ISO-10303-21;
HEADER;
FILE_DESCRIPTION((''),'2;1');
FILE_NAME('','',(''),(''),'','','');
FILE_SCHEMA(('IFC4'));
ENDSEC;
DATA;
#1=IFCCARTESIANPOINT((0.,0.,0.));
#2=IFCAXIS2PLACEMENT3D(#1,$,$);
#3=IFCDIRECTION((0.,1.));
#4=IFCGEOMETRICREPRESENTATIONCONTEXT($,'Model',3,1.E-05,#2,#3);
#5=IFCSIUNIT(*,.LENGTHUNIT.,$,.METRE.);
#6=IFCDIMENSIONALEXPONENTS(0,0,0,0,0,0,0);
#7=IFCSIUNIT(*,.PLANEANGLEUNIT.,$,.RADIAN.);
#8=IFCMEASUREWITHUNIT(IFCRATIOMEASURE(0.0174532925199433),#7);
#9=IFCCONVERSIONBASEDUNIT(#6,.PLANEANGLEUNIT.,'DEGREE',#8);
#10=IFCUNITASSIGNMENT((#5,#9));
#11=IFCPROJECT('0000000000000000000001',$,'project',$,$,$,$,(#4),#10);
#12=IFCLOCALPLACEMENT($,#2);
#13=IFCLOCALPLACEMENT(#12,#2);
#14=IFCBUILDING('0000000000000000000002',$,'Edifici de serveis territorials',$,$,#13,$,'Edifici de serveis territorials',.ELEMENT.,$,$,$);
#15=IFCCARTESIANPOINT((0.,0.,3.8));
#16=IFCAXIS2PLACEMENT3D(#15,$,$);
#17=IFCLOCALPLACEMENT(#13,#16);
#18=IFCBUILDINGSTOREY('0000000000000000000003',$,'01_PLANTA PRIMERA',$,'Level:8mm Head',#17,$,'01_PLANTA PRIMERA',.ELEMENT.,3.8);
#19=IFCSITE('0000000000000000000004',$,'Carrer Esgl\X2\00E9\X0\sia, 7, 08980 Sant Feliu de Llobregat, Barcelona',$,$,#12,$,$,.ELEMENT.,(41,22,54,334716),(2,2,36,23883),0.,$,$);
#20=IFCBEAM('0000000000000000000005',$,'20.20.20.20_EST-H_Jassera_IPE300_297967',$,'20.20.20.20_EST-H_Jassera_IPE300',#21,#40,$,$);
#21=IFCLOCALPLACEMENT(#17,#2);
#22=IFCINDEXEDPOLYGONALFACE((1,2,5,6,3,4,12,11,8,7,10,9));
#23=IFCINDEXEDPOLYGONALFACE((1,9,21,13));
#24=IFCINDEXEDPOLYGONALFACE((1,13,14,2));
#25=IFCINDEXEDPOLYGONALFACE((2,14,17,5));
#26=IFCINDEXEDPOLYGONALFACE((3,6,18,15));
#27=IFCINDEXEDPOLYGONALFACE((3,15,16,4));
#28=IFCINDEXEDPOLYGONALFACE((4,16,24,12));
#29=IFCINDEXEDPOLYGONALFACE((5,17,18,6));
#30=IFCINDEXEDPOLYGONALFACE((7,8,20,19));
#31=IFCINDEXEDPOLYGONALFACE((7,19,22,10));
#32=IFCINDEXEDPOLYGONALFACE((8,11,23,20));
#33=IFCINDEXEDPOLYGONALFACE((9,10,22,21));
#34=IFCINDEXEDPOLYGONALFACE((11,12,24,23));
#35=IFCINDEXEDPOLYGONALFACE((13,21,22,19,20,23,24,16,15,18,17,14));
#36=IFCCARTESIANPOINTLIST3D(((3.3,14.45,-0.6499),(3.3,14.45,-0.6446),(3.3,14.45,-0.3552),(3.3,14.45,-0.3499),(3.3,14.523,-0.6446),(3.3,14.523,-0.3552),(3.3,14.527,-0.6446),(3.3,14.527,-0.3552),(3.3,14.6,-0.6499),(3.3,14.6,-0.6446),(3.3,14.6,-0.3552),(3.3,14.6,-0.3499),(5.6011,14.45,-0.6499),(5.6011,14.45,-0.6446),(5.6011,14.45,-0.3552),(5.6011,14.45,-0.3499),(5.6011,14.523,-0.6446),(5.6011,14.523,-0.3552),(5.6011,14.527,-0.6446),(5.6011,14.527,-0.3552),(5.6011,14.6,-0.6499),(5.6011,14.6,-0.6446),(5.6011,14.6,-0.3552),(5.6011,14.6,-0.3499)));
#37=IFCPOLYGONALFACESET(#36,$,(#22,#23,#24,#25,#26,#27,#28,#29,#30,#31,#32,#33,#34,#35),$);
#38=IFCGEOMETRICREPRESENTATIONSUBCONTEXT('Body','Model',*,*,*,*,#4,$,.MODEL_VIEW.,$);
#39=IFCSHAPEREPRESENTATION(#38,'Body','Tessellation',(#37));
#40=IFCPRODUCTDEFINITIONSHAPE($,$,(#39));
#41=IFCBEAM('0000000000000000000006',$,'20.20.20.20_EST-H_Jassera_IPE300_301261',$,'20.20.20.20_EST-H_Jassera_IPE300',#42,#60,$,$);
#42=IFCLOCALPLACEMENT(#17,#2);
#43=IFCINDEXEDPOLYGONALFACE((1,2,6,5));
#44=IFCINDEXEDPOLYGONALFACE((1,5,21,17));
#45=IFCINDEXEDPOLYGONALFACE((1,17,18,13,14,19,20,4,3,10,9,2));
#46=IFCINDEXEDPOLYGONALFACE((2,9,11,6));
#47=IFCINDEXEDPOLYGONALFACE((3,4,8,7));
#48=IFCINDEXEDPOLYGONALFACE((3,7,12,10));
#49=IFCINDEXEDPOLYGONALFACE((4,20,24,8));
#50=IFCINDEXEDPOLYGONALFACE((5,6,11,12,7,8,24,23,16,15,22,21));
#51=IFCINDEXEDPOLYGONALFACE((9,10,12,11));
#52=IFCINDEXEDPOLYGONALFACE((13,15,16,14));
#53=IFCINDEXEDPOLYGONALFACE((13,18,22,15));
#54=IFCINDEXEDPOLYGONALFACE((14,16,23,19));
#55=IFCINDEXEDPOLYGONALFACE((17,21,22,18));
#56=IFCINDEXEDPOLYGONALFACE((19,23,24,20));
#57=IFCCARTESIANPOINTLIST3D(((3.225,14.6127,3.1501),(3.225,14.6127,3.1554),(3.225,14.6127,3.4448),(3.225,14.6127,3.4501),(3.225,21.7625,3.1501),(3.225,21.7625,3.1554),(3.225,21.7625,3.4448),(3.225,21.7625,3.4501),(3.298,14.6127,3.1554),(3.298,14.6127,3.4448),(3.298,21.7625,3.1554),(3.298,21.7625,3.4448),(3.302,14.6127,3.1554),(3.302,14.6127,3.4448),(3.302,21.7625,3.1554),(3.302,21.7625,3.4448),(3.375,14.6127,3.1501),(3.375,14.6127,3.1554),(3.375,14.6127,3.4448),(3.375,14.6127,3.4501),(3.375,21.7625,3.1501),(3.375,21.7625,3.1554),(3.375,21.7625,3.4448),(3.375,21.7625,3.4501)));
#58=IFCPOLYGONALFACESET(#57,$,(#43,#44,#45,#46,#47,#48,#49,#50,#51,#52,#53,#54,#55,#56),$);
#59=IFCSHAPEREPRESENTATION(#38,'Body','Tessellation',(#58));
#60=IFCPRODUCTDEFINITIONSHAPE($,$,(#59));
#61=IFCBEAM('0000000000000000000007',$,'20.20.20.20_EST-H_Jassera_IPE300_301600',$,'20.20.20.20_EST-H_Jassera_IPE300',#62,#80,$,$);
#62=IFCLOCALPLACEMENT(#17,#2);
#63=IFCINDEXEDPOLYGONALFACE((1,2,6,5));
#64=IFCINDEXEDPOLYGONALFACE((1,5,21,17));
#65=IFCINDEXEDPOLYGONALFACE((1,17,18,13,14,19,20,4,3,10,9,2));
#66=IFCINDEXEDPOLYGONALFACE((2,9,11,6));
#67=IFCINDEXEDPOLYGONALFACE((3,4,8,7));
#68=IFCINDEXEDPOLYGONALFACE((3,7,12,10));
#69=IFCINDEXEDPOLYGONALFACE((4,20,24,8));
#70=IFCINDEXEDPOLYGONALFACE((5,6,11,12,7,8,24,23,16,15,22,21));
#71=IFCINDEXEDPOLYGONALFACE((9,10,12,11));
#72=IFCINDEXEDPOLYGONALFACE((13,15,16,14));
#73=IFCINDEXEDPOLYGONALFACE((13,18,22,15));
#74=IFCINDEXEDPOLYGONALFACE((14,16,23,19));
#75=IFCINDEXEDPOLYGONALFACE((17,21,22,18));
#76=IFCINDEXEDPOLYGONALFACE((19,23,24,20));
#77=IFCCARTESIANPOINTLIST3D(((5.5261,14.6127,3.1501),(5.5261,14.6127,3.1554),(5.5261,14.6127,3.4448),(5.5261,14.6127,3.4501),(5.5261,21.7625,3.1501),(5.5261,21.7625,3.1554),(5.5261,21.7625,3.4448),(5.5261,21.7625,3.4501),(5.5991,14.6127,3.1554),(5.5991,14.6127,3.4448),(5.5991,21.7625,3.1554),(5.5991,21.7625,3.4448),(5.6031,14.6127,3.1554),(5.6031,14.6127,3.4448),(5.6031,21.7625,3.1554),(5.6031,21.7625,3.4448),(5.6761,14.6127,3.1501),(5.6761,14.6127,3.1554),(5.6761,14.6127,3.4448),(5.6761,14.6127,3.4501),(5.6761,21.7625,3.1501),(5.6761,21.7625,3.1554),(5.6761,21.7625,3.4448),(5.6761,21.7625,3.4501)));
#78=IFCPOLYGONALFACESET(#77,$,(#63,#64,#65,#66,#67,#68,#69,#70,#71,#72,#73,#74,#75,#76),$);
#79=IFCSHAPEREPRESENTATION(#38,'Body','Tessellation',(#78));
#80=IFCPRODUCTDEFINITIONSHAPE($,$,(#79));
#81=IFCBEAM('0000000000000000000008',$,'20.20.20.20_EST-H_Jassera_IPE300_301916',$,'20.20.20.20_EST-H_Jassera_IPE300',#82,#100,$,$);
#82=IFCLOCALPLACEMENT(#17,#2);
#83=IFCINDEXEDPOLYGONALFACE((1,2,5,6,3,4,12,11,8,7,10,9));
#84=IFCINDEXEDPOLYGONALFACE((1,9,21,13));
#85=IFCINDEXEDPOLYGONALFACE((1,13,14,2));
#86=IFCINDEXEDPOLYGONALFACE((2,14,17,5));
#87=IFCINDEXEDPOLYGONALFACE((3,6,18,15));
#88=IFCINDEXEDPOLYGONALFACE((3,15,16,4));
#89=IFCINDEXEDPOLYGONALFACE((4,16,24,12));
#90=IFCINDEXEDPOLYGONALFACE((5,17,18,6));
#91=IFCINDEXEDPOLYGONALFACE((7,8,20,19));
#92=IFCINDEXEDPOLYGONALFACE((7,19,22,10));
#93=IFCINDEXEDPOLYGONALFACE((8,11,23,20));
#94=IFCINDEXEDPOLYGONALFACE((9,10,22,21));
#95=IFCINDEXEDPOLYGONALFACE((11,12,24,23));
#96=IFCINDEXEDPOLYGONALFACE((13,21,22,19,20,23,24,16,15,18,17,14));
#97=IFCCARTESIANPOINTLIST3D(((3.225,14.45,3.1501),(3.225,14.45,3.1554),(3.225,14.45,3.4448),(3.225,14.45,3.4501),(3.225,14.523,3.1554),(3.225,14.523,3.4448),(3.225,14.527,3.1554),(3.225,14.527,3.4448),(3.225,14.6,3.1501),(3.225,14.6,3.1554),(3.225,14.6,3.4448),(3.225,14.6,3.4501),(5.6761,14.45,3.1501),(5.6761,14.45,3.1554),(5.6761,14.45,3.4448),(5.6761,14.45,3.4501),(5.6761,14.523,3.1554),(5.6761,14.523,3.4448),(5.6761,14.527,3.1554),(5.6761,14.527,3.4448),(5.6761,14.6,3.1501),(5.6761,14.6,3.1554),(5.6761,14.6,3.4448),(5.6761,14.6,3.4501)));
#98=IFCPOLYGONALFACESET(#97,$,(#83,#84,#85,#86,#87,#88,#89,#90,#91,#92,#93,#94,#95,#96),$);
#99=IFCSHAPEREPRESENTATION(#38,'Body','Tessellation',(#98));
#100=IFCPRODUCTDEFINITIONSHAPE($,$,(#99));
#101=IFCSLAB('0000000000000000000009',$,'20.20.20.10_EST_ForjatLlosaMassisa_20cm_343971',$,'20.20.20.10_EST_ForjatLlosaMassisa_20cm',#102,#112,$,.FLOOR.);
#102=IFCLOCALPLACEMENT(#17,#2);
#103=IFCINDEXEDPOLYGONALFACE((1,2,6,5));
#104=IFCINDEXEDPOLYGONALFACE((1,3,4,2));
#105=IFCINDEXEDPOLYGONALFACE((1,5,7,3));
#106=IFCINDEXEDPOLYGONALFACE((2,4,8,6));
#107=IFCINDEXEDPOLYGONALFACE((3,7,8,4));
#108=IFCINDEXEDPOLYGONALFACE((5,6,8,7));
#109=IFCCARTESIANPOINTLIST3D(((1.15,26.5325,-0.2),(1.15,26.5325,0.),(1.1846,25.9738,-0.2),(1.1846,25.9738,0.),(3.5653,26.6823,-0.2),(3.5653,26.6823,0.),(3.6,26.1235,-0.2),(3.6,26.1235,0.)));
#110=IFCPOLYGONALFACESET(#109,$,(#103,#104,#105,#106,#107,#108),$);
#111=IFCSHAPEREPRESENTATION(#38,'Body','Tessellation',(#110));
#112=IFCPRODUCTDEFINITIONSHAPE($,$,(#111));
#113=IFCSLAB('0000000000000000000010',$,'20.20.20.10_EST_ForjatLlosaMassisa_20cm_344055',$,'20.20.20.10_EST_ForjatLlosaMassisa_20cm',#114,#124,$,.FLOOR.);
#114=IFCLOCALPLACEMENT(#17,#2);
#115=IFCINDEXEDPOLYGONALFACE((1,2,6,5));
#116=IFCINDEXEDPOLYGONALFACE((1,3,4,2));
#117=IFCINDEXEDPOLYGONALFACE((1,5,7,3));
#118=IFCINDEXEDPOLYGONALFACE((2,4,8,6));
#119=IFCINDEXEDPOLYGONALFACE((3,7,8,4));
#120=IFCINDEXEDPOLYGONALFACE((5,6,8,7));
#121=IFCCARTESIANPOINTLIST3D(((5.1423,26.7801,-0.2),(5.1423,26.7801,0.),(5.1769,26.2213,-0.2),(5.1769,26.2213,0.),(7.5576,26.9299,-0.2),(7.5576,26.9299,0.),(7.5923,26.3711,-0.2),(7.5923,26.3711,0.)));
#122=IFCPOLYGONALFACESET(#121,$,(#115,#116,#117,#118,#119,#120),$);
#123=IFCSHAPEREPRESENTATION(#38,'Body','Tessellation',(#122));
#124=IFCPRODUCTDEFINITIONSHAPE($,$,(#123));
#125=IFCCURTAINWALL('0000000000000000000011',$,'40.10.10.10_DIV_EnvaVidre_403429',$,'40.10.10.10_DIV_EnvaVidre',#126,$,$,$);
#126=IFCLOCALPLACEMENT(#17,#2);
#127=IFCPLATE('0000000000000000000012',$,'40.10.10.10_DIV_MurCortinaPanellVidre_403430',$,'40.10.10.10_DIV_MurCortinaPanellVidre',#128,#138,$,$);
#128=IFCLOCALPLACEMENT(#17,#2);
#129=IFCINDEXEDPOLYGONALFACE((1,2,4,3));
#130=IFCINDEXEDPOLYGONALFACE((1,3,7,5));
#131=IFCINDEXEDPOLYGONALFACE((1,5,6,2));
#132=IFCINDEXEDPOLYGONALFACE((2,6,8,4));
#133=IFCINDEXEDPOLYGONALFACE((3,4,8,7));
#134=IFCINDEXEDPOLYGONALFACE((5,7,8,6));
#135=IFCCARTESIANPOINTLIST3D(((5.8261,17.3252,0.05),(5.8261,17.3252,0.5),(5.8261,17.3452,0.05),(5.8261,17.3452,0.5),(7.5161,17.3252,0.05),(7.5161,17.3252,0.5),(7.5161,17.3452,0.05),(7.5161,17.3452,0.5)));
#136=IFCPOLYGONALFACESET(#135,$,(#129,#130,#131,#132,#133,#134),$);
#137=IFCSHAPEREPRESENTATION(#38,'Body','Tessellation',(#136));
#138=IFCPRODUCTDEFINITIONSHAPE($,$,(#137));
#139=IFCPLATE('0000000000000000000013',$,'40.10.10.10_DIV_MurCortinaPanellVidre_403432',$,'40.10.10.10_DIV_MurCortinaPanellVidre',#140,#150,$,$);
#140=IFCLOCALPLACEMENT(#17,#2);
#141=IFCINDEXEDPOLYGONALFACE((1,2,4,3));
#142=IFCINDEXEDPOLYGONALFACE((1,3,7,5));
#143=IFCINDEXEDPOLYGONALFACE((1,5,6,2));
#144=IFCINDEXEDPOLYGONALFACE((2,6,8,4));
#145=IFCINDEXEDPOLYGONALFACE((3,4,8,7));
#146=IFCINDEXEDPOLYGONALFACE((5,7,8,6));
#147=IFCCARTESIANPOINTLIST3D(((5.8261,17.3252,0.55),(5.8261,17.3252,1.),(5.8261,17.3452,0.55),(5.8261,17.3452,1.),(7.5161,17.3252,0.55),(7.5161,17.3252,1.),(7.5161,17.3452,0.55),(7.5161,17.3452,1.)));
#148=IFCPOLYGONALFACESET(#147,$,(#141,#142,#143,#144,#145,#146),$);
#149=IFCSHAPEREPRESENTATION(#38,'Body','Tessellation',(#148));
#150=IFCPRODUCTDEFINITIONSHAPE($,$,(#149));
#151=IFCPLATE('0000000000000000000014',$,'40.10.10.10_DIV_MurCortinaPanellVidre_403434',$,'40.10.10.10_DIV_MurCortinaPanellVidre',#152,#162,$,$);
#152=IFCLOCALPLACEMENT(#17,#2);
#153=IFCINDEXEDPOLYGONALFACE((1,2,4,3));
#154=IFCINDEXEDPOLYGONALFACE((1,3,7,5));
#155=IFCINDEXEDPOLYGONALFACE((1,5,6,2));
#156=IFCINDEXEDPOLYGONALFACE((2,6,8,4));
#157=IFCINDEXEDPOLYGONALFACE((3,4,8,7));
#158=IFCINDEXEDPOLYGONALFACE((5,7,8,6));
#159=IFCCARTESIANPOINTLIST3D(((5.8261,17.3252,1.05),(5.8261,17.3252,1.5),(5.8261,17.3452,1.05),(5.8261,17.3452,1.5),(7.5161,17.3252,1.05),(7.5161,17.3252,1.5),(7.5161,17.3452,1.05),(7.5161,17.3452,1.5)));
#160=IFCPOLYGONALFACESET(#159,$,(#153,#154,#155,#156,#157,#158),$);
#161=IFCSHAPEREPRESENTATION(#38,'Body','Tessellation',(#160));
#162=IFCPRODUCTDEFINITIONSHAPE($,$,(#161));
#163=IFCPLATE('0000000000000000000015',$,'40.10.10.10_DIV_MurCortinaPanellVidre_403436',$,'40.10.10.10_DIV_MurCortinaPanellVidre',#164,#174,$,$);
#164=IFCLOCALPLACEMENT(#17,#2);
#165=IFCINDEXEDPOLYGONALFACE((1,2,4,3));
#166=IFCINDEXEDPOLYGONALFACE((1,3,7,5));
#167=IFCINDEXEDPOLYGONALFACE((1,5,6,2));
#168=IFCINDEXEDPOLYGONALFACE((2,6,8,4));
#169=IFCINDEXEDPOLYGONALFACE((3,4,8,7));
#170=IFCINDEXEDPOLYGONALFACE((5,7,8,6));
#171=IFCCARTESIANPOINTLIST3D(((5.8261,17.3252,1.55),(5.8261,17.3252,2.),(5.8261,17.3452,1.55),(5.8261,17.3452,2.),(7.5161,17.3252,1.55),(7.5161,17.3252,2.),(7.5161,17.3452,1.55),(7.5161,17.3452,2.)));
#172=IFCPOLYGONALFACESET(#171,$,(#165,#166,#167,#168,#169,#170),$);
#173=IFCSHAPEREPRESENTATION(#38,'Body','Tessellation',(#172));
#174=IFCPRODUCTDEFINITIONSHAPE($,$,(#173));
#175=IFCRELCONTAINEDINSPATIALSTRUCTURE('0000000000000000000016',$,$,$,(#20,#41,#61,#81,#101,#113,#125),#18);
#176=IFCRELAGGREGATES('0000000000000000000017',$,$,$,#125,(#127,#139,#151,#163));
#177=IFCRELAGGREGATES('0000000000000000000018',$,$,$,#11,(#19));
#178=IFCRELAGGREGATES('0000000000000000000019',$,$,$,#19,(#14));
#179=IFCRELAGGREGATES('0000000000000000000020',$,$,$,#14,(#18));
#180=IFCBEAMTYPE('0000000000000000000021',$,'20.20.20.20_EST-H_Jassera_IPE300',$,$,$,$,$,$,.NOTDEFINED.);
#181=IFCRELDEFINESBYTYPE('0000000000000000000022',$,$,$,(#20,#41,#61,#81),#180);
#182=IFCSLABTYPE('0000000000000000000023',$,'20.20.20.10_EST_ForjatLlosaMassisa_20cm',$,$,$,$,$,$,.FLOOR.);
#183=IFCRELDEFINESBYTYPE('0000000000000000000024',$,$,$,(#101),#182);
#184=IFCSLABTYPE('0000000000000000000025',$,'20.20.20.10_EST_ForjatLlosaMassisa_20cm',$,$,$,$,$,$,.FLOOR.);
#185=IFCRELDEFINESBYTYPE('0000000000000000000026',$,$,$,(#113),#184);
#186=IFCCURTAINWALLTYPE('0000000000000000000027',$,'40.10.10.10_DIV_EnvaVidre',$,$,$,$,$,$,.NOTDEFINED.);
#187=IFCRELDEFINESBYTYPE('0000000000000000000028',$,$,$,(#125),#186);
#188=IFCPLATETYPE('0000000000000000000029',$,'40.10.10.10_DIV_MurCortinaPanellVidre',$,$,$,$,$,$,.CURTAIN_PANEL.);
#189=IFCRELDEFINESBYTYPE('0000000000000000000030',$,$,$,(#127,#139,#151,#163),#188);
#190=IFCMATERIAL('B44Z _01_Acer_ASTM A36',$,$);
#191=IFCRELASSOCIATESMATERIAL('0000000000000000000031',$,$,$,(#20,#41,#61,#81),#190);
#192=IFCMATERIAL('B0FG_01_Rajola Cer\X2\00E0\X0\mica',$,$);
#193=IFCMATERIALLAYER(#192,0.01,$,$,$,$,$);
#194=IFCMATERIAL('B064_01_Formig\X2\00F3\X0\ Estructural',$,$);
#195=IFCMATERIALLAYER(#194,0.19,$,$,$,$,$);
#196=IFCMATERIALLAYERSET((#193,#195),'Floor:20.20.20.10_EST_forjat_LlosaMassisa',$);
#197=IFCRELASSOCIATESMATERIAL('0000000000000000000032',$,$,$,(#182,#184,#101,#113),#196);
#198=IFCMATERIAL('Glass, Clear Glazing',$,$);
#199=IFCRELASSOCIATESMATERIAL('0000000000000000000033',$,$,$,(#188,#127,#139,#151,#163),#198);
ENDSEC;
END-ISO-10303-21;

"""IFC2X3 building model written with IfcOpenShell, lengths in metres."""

from ifc_helpers import new_model, entity, si_unit, converted_unit, direction, frame, frame_2d, origin, place, context, subcontext, project, spatial, polyline, rectangle, i_section, outline, extrude, source, transform, mapped, material, layer, layer_set, layer_usage, type_object, type_shapes, element, aggregate, save


model = new_model("IFC2X3")

# Units and contexts
model_context = context("Model", 3, precision=1e-05, world=origin(), true_north=direction((0.0, 1.0)))
body_context = subcontext(model_context, "Body", "Model", "MODEL_VIEW")
ifc_project = project(units=[si_unit("LENGTHUNIT", "METRE"), converted_unit("PLANEANGLEUNIT", "DEGREE", entity("IfcRatioMeasure", 0.0174532925199433), si_unit("PLANEANGLEUNIT", "RADIAN"), dimensions=[0, 0, 0, 0, 0, 0, 0])], contexts=[model_context])

# Site, building, storey
site_placement = place(None, origin())
site = spatial("IfcSite", under=ifc_project, at=site_placement, Name="Carrer Església, 7, 08980 Sant Feliu de Llobregat, Barcelona", CompositionType="ELEMENT", RefLatitude=(41, 22, 54, 334716), RefLongitude=(2, 2, 36, 23883), RefElevation=0.0)
building_placement = place(site_placement, origin())
building = spatial("IfcBuilding", under=site, at=building_placement, Name="Edifici de serveis territorials", LongName="Edifici de serveis territorials", CompositionType="ELEMENT")
storey_placement = place(building_placement, frame((0.0, 0.0, 3.8)))
storey = spatial("IfcBuildingStorey", under=building, at=storey_placement, Name="01_PLANTA PRIMERA", ObjectType="Level:8mm Head", LongName="01_PLANTA PRIMERA", CompositionType="ELEMENT", Elevation=3.8)

# Shared definitions
ifc_material_1 = material(Name="B44Z _01_Acer_ASTM A36")

# Beams
beam_type = type_object("IfcBeamType", Name="20.20.20.20_EST-H_Jassera_IPE300", PredefinedType="NOTDEFINED")
beam_1_placement = place(storey_placement, frame((3.3, 14.525, 0.0)))
element("IfcBeam", 1, at=beam_1_placement, inside=storey, type_object=beam_type, material=ifc_material_1, Name="20.20.20.20_EST-H_Jassera_IPE300_297967", ObjectType="20.20.20.20_EST-H_Jassera_IPE300", context=body_context, shape_type="SweptSolid", body=[
    extrude(i_section(OverallWidth=0.15, OverallDepth=0.3, WebThickness=0.0041, FlangeThickness=0.0053, at=frame_2d((0.0, 0.0), x_axis=(0.0, 1.0))), frame((0.0, 0.0, -0.4999), z_axis=(1.0, 0.0, 0.0), x_axis=(0.0, 0.0, -1.0)), (0.0, 0.0, 1.0), 2.3011),
])
beam_2_placement = place(storey_placement, frame((3.3, 14.525, 0.0), z_axis=(0.0, 0.0, 1.0), x_axis=(0.0, 1.0, 0.0)))
element("IfcBeam", 2, at=beam_2_placement, inside=storey, type_object=beam_type, material=ifc_material_1, Name="20.20.20.20_EST-H_Jassera_IPE300_301261", ObjectType="20.20.20.20_EST-H_Jassera_IPE300", context=body_context, shape_type="SweptSolid", body=[
    extrude(i_section(OverallWidth=0.15, OverallDepth=0.3, WebThickness=0.0041, FlangeThickness=0.0053, at=frame_2d((0.0, 0.0), x_axis=(0.0, 1.0))), frame((0.0877, 0.0, 3.3001), z_axis=(1.0, 0.0, 0.0), x_axis=(0.0, 0.0, -1.0)), (0.0, 0.0, 1.0), 7.1498),
])
beam_3_placement = place(storey_placement, frame((5.6011, 14.525, 0.0), z_axis=(0.0, 0.0, 1.0), x_axis=(0.0, 1.0, 0.0)))
element("IfcBeam", 3, at=beam_3_placement, inside=storey, type_object=beam_type, material=ifc_material_1, Name="20.20.20.20_EST-H_Jassera_IPE300_301600", ObjectType="20.20.20.20_EST-H_Jassera_IPE300", context=body_context, shape_type="SweptSolid", body=[
    extrude(i_section(OverallWidth=0.15, OverallDepth=0.3, WebThickness=0.0041, FlangeThickness=0.0053, at=frame_2d((0.0, 0.0), x_axis=(0.0, 1.0))), frame((0.0877, 0.0, 3.3001), z_axis=(1.0, 0.0, 0.0), x_axis=(0.0, 0.0, -1.0)), (0.0, 0.0, 1.0), 7.1498),
])
beam_4_placement = place(storey_placement, frame((3.3, 14.525, 0.0)))
element("IfcBeam", 4, at=beam_4_placement, inside=storey, type_object=beam_type, material=ifc_material_1, Name="20.20.20.20_EST-H_Jassera_IPE300_301916", ObjectType="20.20.20.20_EST-H_Jassera_IPE300", context=body_context, shape_type="SweptSolid", body=[
    extrude(i_section(OverallWidth=0.15, OverallDepth=0.3, WebThickness=0.0041, FlangeThickness=0.0053, at=frame_2d((0.0, 0.0), x_axis=(0.0, 1.0))), frame((-0.075, 0.0, 3.3001), z_axis=(1.0, 0.0, 0.0), x_axis=(0.0, 0.0, -1.0)), (0.0, 0.0, 1.0), 2.4511),
])

# Slabs
ifc_material_2 = material(Name="B064_01_Formigó Estructural")
ifc_material_3 = material(Name="B0FG_01_Rajola Ceràmica")
ifc_layer_1 = layer(ifc_material_3, 0.01)
ifc_layer_2 = layer(ifc_material_2, 0.19)
ifc_layer_set_1 = layer_set([ifc_layer_1, ifc_layer_2], Name="Floor:20.20.20.10_EST_forjat_LlosaMassisa")
ifc_layer_usage_1 = layer_usage(ifc_layer_set_1, "AXIS3", "POSITIVE", 0.0)
slab_type_1 = type_object("IfcSlabType", Name="20.20.20.10_EST_ForjatLlosaMassisa_20cm", PredefinedType="FLOOR", material=ifc_layer_set_1)
slab_1_placement = place(storey_placement, origin())
element("IfcSlab", 5, at=slab_1_placement, inside=storey, type_object=slab_type_1, material=ifc_layer_usage_1, Name="20.20.20.10_EST_ForjatLlosaMassisa_20cm_343971", ObjectType="20.20.20.10_EST_ForjatLlosaMassisa_20cm", PredefinedType="FLOOR", context=body_context, shape_type="SweptSolid", body=[
    extrude(outline(polyline([(-1.21, -0.2799), (1.21, -0.2799), (1.21, 0.2799), (-1.21, 0.2799), (-1.21, -0.2799)])), frame((2.375, 26.328, 0.0), z_axis=(0.0, 0.0, -1.0), x_axis=(0.998083, 0.061896, 0.0)), (0.0, 0.0, 1.0), 0.2),
])
ifc_layer_usage_2 = layer_usage(ifc_layer_set_1, "AXIS3", "POSITIVE", 0.0)
slab_type_2 = type_object("IfcSlabType", Name="20.20.20.10_EST_ForjatLlosaMassisa_20cm", PredefinedType="FLOOR", material=ifc_layer_set_1)
slab_2_placement = place(storey_placement, origin())
element("IfcSlab", 6, at=slab_2_placement, inside=storey, type_object=slab_type_2, material=ifc_layer_usage_2, Name="20.20.20.10_EST_ForjatLlosaMassisa_20cm_344055", ObjectType="20.20.20.10_EST_ForjatLlosaMassisa_20cm", PredefinedType="FLOOR", context=body_context, shape_type="SweptSolid", body=[
    extrude(outline(polyline([(-1.21, -0.2799), (1.21, -0.2799), (1.21, 0.2799), (-1.21, 0.2799), (-1.21, -0.2799)])), frame((6.3673, 26.5756, 0.0), z_axis=(0.0, 0.0, -1.0), x_axis=(0.998083, 0.061896, 0.0)), (0.0, 0.0, 1.0), 0.2),
])

# Curtain wall, plates
curtain_wall_type = type_object("IfcCurtainWallType", Name="40.10.10.10_DIV_EnvaVidre", PredefinedType="NOTDEFINED")
curtain_wall_placement = place(storey_placement, frame((0.0, 0.0, -3.8)))
curtain_wall = element("IfcCurtainWall", 7, at=curtain_wall_placement, inside=storey, type_object=curtain_wall_type, Name="40.10.10.10_DIV_EnvaVidre_403429", ObjectType="40.10.10.10_DIV_EnvaVidre")
ifc_material_4 = material(Name="Glass, Clear Glazing")
plate_type = type_object("IfcPlateType", Name="40.10.10.10_DIV_MurCortinaPanellVidre", PredefinedType="CURTAIN_PANEL", material=ifc_material_4)
shared_shape_1 = source(origin(), body_context, "Body", "SweptSolid", [
    extrude(rectangle(XDim=0.02, YDim=1.69, at=frame_2d((0.0, 0.0), x_axis=(1.0, 0.0))), frame((0.845, 0.01, 0.0), z_axis=(0.0, 0.0, 1.0), x_axis=(0.0, 1.0, 0.0)), (0.0, 0.0, 1.0), 0.45),
])
type_shapes(plate_type, [shared_shape_1])
plate_1_placement = place(curtain_wall_placement, frame((7.5161, 17.3452, 3.85), z_axis=(0.0, 0.0, 1.0), x_axis=(-1.0, 0.0, 0.0)))
plate_1 = element("IfcPlate", 8, at=plate_1_placement, type_object=plate_type, material=ifc_material_4, Name="40.10.10.10_DIV_MurCortinaPanellVidre_403430", ObjectType="40.10.10.10_DIV_MurCortinaPanellVidre", context=body_context, shape_type="MappedRepresentation", body=[
    mapped(shared_shape_1, transform((0.0, 0.0, 0.0), scale=1.0)),
])
plate_2_placement = place(curtain_wall_placement, frame((7.5161, 17.3452, 4.35), z_axis=(0.0, 0.0, 1.0), x_axis=(-1.0, 0.0, 0.0)))
plate_2 = element("IfcPlate", 9, at=plate_2_placement, type_object=plate_type, material=ifc_material_4, Name="40.10.10.10_DIV_MurCortinaPanellVidre_403432", ObjectType="40.10.10.10_DIV_MurCortinaPanellVidre", context=body_context, shape_type="MappedRepresentation", body=[
    mapped(shared_shape_1, transform((0.0, 0.0, 0.0), scale=1.0)),
])
plate_3_placement = place(curtain_wall_placement, frame((7.5161, 17.3452, 4.85), z_axis=(0.0, 0.0, 1.0), x_axis=(-1.0, 0.0, 0.0)))
plate_3 = element("IfcPlate", 10, at=plate_3_placement, type_object=plate_type, material=ifc_material_4, Name="40.10.10.10_DIV_MurCortinaPanellVidre_403434", ObjectType="40.10.10.10_DIV_MurCortinaPanellVidre", context=body_context, shape_type="MappedRepresentation", body=[
    mapped(shared_shape_1, transform((0.0, 0.0, 0.0), scale=1.0)),
])
plate_4_placement = place(curtain_wall_placement, frame((7.5161, 17.3452, 5.35), z_axis=(0.0, 0.0, 1.0), x_axis=(-1.0, 0.0, 0.0)))
plate_4 = element("IfcPlate", 11, at=plate_4_placement, type_object=plate_type, material=ifc_material_4, Name="40.10.10.10_DIV_MurCortinaPanellVidre_403436", ObjectType="40.10.10.10_DIV_MurCortinaPanellVidre", context=body_context, shape_type="MappedRepresentation", body=[
    mapped(shared_shape_1, transform((0.0, 0.0, 0.0), scale=1.0)),
])
aggregate(curtain_wall, [plate_1, plate_2, plate_3, plate_4])

save(model, "model.ifc")
